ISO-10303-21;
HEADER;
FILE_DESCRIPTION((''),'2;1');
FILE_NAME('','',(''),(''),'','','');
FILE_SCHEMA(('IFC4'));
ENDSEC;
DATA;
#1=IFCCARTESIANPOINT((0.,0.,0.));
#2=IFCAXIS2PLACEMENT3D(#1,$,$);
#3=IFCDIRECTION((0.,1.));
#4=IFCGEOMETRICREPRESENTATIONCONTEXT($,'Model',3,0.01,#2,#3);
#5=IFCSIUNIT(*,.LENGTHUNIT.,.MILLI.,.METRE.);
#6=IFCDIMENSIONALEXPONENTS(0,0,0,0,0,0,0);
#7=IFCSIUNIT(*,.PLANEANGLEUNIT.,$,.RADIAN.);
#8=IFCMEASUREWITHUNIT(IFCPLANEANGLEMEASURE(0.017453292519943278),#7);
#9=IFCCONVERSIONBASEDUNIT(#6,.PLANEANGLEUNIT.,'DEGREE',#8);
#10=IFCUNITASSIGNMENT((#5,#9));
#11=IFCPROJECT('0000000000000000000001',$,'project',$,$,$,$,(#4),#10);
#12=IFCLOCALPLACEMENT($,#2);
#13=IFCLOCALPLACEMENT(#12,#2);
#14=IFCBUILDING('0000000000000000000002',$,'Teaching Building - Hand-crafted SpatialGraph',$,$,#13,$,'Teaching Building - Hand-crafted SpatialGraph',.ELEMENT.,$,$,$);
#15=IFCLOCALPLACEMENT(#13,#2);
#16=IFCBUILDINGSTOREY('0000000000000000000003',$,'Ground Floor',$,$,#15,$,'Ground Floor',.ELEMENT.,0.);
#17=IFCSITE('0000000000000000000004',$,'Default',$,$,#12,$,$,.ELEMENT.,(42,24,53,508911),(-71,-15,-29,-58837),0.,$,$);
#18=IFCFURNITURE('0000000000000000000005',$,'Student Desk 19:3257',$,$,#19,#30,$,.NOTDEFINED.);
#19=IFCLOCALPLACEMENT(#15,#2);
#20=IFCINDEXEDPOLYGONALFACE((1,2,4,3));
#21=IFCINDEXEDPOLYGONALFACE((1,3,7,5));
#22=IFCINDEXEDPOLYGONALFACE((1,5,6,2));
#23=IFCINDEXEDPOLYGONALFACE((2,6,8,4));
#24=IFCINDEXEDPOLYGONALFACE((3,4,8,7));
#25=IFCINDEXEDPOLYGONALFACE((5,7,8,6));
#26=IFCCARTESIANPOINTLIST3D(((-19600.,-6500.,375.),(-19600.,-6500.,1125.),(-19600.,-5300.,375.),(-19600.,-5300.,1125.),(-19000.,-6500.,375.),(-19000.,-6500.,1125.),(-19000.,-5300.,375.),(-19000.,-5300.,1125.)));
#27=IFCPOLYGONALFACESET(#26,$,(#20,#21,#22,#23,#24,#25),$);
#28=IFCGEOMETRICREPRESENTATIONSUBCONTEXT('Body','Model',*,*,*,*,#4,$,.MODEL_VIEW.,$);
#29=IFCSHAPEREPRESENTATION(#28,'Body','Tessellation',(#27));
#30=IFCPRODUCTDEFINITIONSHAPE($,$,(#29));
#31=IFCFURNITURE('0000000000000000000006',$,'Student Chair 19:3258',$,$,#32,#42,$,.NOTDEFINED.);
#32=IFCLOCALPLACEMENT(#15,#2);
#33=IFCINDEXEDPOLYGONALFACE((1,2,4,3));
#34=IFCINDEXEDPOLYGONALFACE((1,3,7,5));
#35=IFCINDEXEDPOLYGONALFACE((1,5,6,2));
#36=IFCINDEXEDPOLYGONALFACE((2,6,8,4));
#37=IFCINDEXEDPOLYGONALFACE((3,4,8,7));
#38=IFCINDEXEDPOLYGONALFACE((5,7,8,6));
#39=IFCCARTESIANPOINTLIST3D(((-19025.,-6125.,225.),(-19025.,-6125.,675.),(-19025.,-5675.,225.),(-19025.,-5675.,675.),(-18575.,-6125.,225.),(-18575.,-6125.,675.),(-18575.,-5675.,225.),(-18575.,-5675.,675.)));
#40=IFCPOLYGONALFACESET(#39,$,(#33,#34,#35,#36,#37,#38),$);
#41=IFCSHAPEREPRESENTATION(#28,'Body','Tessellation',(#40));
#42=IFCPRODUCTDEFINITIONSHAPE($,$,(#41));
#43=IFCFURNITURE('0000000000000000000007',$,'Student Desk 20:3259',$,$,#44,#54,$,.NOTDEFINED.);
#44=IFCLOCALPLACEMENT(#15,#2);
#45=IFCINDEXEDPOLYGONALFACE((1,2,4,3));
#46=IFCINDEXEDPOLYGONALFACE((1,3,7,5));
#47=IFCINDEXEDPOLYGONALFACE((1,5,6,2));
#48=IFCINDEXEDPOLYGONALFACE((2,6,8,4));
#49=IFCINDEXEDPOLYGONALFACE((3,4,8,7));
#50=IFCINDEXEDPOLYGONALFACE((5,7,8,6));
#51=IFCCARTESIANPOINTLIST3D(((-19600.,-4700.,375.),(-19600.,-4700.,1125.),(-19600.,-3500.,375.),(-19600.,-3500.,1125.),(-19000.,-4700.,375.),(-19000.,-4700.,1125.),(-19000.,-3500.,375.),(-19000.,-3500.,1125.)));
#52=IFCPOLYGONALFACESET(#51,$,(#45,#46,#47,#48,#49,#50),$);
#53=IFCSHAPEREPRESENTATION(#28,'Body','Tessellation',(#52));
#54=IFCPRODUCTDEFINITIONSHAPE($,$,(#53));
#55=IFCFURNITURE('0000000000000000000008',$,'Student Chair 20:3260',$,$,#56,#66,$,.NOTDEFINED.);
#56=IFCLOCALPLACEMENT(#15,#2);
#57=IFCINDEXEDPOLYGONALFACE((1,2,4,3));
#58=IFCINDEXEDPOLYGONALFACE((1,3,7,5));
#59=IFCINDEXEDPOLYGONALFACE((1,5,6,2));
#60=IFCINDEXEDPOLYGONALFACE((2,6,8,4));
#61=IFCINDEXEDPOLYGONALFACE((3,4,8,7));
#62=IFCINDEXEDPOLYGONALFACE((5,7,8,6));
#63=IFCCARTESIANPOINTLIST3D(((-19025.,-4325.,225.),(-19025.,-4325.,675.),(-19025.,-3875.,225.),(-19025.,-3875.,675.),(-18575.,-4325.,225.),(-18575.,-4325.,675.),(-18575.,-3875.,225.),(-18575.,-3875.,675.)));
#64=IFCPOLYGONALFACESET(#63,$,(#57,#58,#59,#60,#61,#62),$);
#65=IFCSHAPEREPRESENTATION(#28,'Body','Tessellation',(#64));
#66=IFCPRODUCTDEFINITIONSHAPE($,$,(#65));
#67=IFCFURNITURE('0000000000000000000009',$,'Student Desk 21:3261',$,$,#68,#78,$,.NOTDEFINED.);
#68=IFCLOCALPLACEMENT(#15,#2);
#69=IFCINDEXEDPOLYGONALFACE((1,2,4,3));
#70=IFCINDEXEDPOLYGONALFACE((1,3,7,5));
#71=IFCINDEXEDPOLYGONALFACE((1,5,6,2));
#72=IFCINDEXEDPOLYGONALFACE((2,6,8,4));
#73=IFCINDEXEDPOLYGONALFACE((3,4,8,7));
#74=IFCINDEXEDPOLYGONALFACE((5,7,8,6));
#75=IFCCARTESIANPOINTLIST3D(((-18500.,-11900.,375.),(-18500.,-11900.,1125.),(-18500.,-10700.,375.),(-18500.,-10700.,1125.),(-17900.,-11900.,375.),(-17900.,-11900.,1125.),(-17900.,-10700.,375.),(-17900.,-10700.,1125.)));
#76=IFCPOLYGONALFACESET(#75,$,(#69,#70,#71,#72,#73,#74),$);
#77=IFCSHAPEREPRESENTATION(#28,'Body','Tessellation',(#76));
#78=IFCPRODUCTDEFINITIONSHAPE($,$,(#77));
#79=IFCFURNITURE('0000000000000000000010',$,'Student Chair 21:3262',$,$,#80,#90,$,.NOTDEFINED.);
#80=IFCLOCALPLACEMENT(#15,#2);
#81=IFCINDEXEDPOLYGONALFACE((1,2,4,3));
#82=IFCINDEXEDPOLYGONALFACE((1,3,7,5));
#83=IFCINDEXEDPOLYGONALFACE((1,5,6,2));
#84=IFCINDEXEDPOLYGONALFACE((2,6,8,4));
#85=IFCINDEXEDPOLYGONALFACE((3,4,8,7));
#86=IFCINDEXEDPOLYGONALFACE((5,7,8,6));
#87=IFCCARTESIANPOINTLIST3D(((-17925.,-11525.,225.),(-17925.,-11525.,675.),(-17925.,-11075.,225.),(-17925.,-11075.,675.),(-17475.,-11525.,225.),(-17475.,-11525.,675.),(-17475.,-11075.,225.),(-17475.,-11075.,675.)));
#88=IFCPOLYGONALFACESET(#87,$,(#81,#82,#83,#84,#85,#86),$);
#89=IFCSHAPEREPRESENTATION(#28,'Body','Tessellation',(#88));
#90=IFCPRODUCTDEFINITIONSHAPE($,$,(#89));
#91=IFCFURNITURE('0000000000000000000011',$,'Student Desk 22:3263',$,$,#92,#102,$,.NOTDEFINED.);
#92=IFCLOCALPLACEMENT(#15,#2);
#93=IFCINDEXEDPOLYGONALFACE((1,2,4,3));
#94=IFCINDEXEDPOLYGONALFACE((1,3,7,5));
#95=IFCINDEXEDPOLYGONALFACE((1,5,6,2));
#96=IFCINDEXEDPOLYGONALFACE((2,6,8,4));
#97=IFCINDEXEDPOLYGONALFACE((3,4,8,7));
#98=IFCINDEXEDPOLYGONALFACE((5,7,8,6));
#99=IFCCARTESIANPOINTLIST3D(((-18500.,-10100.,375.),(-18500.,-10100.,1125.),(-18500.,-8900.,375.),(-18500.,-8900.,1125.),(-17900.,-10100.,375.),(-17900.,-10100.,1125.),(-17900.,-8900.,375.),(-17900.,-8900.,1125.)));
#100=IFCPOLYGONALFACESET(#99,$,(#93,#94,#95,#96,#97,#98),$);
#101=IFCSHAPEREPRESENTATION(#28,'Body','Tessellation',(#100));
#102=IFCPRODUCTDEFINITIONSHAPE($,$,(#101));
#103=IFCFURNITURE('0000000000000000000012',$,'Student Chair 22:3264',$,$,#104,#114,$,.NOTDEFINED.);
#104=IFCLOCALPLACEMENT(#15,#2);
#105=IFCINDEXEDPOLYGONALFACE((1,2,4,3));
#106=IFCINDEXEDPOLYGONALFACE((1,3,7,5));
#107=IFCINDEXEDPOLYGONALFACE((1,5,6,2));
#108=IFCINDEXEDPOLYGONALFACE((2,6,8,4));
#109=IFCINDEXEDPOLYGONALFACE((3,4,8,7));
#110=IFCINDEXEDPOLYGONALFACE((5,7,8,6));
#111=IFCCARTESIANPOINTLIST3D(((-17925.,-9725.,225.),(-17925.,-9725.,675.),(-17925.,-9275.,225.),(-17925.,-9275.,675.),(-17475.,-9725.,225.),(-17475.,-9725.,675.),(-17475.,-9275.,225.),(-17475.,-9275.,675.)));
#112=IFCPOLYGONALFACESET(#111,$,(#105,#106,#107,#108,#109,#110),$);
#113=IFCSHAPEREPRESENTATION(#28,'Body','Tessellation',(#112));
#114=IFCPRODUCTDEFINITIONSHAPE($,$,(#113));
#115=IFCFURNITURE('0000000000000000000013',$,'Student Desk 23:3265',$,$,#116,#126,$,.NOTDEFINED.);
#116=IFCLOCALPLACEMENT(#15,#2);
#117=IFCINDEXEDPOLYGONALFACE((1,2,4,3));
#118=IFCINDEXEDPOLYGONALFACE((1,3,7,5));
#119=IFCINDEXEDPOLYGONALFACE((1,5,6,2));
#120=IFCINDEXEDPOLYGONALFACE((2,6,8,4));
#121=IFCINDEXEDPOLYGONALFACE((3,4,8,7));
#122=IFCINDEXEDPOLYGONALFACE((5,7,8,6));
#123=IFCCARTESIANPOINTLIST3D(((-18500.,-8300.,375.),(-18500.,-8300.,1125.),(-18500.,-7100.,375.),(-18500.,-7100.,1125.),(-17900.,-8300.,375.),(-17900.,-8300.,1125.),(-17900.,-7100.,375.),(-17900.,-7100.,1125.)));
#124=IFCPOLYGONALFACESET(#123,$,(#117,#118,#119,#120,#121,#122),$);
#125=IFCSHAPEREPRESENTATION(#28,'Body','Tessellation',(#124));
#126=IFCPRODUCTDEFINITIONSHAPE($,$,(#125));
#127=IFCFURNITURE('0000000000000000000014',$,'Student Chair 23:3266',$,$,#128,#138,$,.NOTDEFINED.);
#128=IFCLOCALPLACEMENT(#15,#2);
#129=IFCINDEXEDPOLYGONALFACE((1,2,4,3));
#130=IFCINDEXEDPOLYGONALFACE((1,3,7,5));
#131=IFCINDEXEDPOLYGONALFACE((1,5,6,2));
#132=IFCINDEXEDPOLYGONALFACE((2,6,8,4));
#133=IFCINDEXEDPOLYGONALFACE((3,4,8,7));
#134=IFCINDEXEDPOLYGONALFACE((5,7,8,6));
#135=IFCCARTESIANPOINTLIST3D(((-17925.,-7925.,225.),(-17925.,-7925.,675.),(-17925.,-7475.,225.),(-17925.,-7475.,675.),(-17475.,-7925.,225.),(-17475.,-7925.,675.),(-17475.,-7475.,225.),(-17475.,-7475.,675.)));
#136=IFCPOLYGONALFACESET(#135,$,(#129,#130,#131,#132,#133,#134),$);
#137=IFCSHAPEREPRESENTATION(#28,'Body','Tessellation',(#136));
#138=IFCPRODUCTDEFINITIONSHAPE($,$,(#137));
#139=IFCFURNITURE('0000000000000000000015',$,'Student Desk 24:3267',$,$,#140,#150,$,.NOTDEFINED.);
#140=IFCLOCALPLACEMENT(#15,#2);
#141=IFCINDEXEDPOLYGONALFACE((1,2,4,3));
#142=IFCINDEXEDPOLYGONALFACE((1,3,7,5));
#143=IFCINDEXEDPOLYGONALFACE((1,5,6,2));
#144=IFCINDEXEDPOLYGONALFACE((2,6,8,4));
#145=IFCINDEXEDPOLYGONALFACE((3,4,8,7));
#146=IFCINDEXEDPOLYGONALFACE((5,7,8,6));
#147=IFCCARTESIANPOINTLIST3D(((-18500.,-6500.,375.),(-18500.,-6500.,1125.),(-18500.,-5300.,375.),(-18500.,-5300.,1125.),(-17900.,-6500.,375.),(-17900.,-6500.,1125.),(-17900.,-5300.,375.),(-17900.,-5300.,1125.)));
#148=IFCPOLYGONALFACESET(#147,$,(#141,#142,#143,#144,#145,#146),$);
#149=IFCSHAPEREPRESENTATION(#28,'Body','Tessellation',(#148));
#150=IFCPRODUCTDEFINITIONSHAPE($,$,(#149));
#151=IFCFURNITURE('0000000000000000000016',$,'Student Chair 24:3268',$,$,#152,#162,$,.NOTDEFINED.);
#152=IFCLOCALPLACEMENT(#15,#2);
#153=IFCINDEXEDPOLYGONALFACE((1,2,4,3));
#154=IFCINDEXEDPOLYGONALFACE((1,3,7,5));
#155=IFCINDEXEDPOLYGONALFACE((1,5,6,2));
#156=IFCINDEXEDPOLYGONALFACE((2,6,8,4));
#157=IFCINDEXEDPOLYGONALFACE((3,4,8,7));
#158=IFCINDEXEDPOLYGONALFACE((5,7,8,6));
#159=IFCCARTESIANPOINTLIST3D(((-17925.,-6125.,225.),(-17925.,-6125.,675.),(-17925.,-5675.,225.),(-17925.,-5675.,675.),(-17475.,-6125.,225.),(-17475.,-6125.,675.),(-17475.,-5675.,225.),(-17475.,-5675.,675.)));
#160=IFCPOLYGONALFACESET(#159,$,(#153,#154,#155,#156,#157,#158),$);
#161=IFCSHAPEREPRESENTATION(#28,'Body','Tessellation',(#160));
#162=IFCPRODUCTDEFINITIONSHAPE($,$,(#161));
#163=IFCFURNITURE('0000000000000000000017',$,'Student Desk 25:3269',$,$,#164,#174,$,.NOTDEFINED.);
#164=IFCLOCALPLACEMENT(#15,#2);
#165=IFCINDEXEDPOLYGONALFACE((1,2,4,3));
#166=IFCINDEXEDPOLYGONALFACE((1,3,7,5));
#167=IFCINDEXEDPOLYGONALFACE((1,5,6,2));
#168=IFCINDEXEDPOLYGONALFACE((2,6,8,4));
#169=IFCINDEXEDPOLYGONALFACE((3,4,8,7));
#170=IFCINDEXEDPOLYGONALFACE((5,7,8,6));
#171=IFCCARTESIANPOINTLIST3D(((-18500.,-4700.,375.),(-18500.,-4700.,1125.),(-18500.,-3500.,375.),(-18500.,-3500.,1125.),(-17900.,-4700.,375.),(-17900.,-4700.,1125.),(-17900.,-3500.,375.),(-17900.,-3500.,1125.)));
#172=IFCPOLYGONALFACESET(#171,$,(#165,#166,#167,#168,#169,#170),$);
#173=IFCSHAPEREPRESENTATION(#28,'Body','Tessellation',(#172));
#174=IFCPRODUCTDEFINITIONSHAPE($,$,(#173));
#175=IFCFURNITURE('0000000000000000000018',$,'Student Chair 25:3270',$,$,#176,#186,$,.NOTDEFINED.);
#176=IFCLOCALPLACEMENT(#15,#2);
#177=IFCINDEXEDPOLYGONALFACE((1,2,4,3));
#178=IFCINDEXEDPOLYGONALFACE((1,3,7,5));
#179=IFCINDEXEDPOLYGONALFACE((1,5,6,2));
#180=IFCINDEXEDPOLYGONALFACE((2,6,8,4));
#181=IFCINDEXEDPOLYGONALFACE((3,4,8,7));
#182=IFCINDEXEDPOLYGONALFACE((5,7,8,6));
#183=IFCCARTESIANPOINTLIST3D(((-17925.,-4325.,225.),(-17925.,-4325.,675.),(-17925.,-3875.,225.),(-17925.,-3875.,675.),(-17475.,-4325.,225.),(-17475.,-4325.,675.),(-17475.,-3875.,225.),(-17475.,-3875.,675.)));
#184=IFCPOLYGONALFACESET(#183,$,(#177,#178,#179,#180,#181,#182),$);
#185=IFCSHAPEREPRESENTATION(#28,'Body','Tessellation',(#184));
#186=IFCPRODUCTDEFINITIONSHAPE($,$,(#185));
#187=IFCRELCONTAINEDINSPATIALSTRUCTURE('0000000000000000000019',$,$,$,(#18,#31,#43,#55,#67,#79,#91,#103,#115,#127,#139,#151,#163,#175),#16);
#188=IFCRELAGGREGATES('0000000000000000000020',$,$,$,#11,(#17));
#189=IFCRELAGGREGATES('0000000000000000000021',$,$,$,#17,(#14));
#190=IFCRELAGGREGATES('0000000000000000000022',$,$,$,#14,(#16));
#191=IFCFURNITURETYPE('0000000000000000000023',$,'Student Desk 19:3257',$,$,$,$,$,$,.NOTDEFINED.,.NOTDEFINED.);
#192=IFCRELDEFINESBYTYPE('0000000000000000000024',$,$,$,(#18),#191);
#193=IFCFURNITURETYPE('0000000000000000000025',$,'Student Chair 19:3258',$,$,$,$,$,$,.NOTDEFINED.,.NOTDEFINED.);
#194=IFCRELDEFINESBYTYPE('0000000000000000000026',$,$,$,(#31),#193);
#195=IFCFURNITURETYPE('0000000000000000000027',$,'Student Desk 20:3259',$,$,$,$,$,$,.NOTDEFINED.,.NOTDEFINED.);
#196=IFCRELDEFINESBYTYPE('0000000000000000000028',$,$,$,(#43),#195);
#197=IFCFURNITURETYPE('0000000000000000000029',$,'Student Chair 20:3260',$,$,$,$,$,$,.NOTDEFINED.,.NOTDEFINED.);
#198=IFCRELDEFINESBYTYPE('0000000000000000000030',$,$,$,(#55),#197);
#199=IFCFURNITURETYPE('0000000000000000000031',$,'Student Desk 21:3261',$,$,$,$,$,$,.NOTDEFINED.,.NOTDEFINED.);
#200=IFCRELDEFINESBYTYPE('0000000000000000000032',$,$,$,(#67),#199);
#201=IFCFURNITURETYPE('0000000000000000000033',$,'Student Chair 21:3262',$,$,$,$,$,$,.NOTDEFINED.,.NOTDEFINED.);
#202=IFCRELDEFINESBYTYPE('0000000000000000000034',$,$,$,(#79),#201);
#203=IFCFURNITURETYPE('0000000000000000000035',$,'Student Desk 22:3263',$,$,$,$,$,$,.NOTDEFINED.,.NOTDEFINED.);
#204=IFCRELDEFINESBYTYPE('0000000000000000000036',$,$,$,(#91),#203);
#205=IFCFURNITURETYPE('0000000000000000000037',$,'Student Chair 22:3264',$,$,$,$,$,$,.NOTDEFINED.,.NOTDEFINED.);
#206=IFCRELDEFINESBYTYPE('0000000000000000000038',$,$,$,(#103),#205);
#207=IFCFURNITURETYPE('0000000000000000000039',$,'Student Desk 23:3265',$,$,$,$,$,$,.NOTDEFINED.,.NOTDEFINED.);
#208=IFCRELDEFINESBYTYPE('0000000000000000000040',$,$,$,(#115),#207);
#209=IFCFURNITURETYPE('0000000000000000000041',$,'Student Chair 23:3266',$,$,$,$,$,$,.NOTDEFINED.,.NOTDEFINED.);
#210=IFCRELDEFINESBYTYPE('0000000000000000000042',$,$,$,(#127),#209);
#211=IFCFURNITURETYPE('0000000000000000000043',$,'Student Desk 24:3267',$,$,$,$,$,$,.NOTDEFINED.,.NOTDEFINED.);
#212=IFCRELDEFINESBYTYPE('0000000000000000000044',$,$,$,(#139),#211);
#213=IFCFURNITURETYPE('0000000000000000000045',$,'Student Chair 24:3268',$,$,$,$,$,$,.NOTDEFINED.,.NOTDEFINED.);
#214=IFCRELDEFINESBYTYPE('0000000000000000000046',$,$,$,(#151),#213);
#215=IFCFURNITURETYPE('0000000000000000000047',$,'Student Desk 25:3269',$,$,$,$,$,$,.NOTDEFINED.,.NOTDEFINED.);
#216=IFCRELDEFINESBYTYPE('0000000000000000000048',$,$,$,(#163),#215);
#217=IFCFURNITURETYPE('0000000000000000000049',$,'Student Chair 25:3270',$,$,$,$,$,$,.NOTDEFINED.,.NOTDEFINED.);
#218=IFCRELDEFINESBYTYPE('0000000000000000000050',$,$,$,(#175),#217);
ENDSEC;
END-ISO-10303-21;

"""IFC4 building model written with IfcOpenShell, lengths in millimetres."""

from ifc_helpers import new_model, entity, si_unit, converted_unit, direction, frame, frame_2d, origin, origin_2d_with_axis, place, context, subcontext, project, spatial, rectangle, extrude, type_object, element, save


model = new_model("IFC4")

# Units and contexts
model_context = context("Model", 3, precision=0.01, world=origin(), true_north=direction((0.0, 1.0)))
body_context = subcontext(model_context, "Body", "Model", "MODEL_VIEW")
ifc_project = project(units=[si_unit("LENGTHUNIT", "METRE", prefix="MILLI"), converted_unit("PLANEANGLEUNIT", "DEGREE", entity("IfcPlaneAngleMeasure", 0.017453292519943278), si_unit("PLANEANGLEUNIT", "RADIAN"), dimensions=[0, 0, 0, 0, 0, 0, 0])], contexts=[model_context])

# Site, building, storey
site_placement = place(None, origin())
site = spatial("IfcSite", under=ifc_project, at=site_placement, Name="Default", CompositionType="ELEMENT", RefLatitude=(42, 24, 53, 508911), RefLongitude=(-71, -15, -29, -58837), RefElevation=0.0)
building_placement = place(site_placement, origin())
building = spatial("IfcBuilding", under=site, at=building_placement, Name="Teaching Building - Hand-crafted SpatialGraph", LongName="Teaching Building - Hand-crafted SpatialGraph", CompositionType="ELEMENT")
storey_placement = place(building_placement, origin())
storey = spatial("IfcBuildingStorey", under=building, at=storey_placement, Name="Ground Floor", LongName="Ground Floor", CompositionType="ELEMENT", Elevation=0.0)

# Furniture
furniture_type_1 = type_object("IfcFurnitureType", Name="Student Desk 19:3257", PredefinedType="NOTDEFINED")
furniture_1_placement = place(storey_placement, origin())
element("IfcFurniture", 1, at=furniture_1_placement, inside=storey, type_object=furniture_type_1, Name="Student Desk 19:3257", PredefinedType="NOTDEFINED", context=body_context, shape_type="SweptSolid", body=[
    extrude(rectangle(XDim=1200.0, YDim=600.0, at=frame_2d((0.0, 0.0), x_axis=(1.0, 0.0))), frame((-19300.0, -5900.0, 375.0), z_axis=(0.0, 0.0, 1.0), x_axis=(0.0, 1.0, 0.0)), (0.0, 0.0, 1.0), 750.0),
])
furniture_type_2 = type_object("IfcFurnitureType", Name="Student Chair 19:3258", PredefinedType="NOTDEFINED")
furniture_2_placement = place(storey_placement, origin())
element("IfcFurniture", 2, at=furniture_2_placement, inside=storey, type_object=furniture_type_2, Name="Student Chair 19:3258", PredefinedType="NOTDEFINED", context=body_context, shape_type="SweptSolid", body=[
    extrude(rectangle(XDim=450.0, YDim=450.0, at=origin_2d_with_axis()), frame((-18800.0, -5900.0, 225.0)), (0.0, 0.0, 1.0), 450.0),
])
furniture_type_3 = type_object("IfcFurnitureType", Name="Student Desk 20:3259", PredefinedType="NOTDEFINED")
furniture_3_placement = place(storey_placement, origin())
element("IfcFurniture", 3, at=furniture_3_placement, inside=storey, type_object=furniture_type_3, Name="Student Desk 20:3259", PredefinedType="NOTDEFINED", context=body_context, shape_type="SweptSolid", body=[
    extrude(rectangle(XDim=1200.0, YDim=600.0, at=frame_2d((0.0, 0.0), x_axis=(1.0, 0.0))), frame((-19300.0, -4100.0, 375.0), z_axis=(0.0, 0.0, 1.0), x_axis=(0.0, 1.0, 0.0)), (0.0, 0.0, 1.0), 750.0),
])
furniture_type_4 = type_object("IfcFurnitureType", Name="Student Chair 20:3260", PredefinedType="NOTDEFINED")
furniture_4_placement = place(storey_placement, origin())
element("IfcFurniture", 4, at=furniture_4_placement, inside=storey, type_object=furniture_type_4, Name="Student Chair 20:3260", PredefinedType="NOTDEFINED", context=body_context, shape_type="SweptSolid", body=[
    extrude(rectangle(XDim=450.0, YDim=450.0, at=origin_2d_with_axis()), frame((-18800.0, -4100.0, 225.0)), (0.0, 0.0, 1.0), 450.0),
])
furniture_type_5 = type_object("IfcFurnitureType", Name="Student Desk 21:3261", PredefinedType="NOTDEFINED")
furniture_5_placement = place(storey_placement, origin())
element("IfcFurniture", 5, at=furniture_5_placement, inside=storey, type_object=furniture_type_5, Name="Student Desk 21:3261", PredefinedType="NOTDEFINED", context=body_context, shape_type="SweptSolid", body=[
    extrude(rectangle(XDim=1200.0, YDim=600.0, at=origin_2d_with_axis()), frame((-18200.0, -11300.0, 375.0), z_axis=(0.0, 0.0, 1.0), x_axis=(0.0, 1.0, 0.0)), (0.0, 0.0, 1.0), 750.0),
])
furniture_type_6 = type_object("IfcFurnitureType", Name="Student Chair 21:3262", PredefinedType="NOTDEFINED")
furniture_6_placement = place(storey_placement, origin())
element("IfcFurniture", 6, at=furniture_6_placement, inside=storey, type_object=furniture_type_6, Name="Student Chair 21:3262", PredefinedType="NOTDEFINED", context=body_context, shape_type="SweptSolid", body=[
    extrude(rectangle(XDim=450.0, YDim=450.0, at=origin_2d_with_axis()), frame((-17700.0, -11300.0, 225.0)), (0.0, 0.0, 1.0), 450.0),
])
furniture_type_7 = type_object("IfcFurnitureType", Name="Student Desk 22:3263", PredefinedType="NOTDEFINED")
furniture_7_placement = place(storey_placement, origin())
element("IfcFurniture", 7, at=furniture_7_placement, inside=storey, type_object=furniture_type_7, Name="Student Desk 22:3263", PredefinedType="NOTDEFINED", context=body_context, shape_type="SweptSolid", body=[
    extrude(rectangle(XDim=1200.0, YDim=600.0, at=origin_2d_with_axis()), frame((-18200.0, -9500.0, 375.0), z_axis=(0.0, 0.0, 1.0), x_axis=(0.0, 1.0, 0.0)), (0.0, 0.0, 1.0), 750.0),
])
furniture_type_8 = type_object("IfcFurnitureType", Name="Student Chair 22:3264", PredefinedType="NOTDEFINED")
furniture_8_placement = place(storey_placement, origin())
element("IfcFurniture", 8, at=furniture_8_placement, inside=storey, type_object=furniture_type_8, Name="Student Chair 22:3264", PredefinedType="NOTDEFINED", context=body_context, shape_type="SweptSolid", body=[
    extrude(rectangle(XDim=450.0, YDim=450.0, at=origin_2d_with_axis()), frame((-17700.0, -9500.0, 225.0)), (0.0, 0.0, 1.0), 450.0),
])
furniture_type_9 = type_object("IfcFurnitureType", Name="Student Desk 23:3265", PredefinedType="NOTDEFINED")
furniture_9_placement = place(storey_placement, origin())
element("IfcFurniture", 9, at=furniture_9_placement, inside=storey, type_object=furniture_type_9, Name="Student Desk 23:3265", PredefinedType="NOTDEFINED", context=body_context, shape_type="SweptSolid", body=[
    extrude(rectangle(XDim=1200.0, YDim=600.0, at=origin_2d_with_axis()), frame((-18200.0, -7700.0, 375.0), z_axis=(0.0, 0.0, 1.0), x_axis=(0.0, 1.0, 0.0)), (0.0, 0.0, 1.0), 750.0),
])
furniture_type_10 = type_object("IfcFurnitureType", Name="Student Chair 23:3266", PredefinedType="NOTDEFINED")
furniture_10_placement = place(storey_placement, origin())
element("IfcFurniture", 10, at=furniture_10_placement, inside=storey, type_object=furniture_type_10, Name="Student Chair 23:3266", PredefinedType="NOTDEFINED", context=body_context, shape_type="SweptSolid", body=[
    extrude(rectangle(XDim=450.0, YDim=450.0, at=frame_2d((0.0, 0.0), x_axis=(1.0, 0.0))), frame((-17700.0, -7700.0, 225.0)), (0.0, 0.0, 1.0), 450.0),
])
furniture_type_11 = type_object("IfcFurnitureType", Name="Student Desk 24:3267", PredefinedType="NOTDEFINED")
furniture_11_placement = place(storey_placement, origin())
element("IfcFurniture", 11, at=furniture_11_placement, inside=storey, type_object=furniture_type_11, Name="Student Desk 24:3267", PredefinedType="NOTDEFINED", context=body_context, shape_type="SweptSolid", body=[
    extrude(rectangle(XDim=1200.0, YDim=600.0, at=origin_2d_with_axis()), frame((-18200.0, -5900.0, 375.0), z_axis=(0.0, 0.0, 1.0), x_axis=(0.0, 1.0, 0.0)), (0.0, 0.0, 1.0), 750.0),
])
furniture_type_12 = type_object("IfcFurnitureType", Name="Student Chair 24:3268", PredefinedType="NOTDEFINED")
furniture_12_placement = place(storey_placement, origin())
element("IfcFurniture", 12, at=furniture_12_placement, inside=storey, type_object=furniture_type_12, Name="Student Chair 24:3268", PredefinedType="NOTDEFINED", context=body_context, shape_type="SweptSolid", body=[
    extrude(rectangle(XDim=450.0, YDim=450.0, at=origin_2d_with_axis()), frame((-17700.0, -5900.0, 225.0)), (0.0, 0.0, 1.0), 450.0),
])
furniture_type_13 = type_object("IfcFurnitureType", Name="Student Desk 25:3269", PredefinedType="NOTDEFINED")
furniture_13_placement = place(storey_placement, origin())
element("IfcFurniture", 13, at=furniture_13_placement, inside=storey, type_object=furniture_type_13, Name="Student Desk 25:3269", PredefinedType="NOTDEFINED", context=body_context, shape_type="SweptSolid", body=[
    extrude(rectangle(XDim=1200.0, YDim=600.0, at=origin_2d_with_axis()), frame((-18200.0, -4100.0, 375.0), z_axis=(0.0, 0.0, 1.0), x_axis=(0.0, 1.0, 0.0)), (0.0, 0.0, 1.0), 750.0),
])
furniture_type_14 = type_object("IfcFurnitureType", Name="Student Chair 25:3270", PredefinedType="NOTDEFINED")
furniture_14_placement = place(storey_placement, origin())
element("IfcFurniture", 14, at=furniture_14_placement, inside=storey, type_object=furniture_type_14, Name="Student Chair 25:3270", PredefinedType="NOTDEFINED", context=body_context, shape_type="SweptSolid", body=[
    extrude(rectangle(XDim=450.0, YDim=450.0, at=origin_2d_with_axis()), frame((-17700.0, -4100.0, 225.0)), (0.0, 0.0, 1.0), 450.0),
])

save(model, "model.ifc")
